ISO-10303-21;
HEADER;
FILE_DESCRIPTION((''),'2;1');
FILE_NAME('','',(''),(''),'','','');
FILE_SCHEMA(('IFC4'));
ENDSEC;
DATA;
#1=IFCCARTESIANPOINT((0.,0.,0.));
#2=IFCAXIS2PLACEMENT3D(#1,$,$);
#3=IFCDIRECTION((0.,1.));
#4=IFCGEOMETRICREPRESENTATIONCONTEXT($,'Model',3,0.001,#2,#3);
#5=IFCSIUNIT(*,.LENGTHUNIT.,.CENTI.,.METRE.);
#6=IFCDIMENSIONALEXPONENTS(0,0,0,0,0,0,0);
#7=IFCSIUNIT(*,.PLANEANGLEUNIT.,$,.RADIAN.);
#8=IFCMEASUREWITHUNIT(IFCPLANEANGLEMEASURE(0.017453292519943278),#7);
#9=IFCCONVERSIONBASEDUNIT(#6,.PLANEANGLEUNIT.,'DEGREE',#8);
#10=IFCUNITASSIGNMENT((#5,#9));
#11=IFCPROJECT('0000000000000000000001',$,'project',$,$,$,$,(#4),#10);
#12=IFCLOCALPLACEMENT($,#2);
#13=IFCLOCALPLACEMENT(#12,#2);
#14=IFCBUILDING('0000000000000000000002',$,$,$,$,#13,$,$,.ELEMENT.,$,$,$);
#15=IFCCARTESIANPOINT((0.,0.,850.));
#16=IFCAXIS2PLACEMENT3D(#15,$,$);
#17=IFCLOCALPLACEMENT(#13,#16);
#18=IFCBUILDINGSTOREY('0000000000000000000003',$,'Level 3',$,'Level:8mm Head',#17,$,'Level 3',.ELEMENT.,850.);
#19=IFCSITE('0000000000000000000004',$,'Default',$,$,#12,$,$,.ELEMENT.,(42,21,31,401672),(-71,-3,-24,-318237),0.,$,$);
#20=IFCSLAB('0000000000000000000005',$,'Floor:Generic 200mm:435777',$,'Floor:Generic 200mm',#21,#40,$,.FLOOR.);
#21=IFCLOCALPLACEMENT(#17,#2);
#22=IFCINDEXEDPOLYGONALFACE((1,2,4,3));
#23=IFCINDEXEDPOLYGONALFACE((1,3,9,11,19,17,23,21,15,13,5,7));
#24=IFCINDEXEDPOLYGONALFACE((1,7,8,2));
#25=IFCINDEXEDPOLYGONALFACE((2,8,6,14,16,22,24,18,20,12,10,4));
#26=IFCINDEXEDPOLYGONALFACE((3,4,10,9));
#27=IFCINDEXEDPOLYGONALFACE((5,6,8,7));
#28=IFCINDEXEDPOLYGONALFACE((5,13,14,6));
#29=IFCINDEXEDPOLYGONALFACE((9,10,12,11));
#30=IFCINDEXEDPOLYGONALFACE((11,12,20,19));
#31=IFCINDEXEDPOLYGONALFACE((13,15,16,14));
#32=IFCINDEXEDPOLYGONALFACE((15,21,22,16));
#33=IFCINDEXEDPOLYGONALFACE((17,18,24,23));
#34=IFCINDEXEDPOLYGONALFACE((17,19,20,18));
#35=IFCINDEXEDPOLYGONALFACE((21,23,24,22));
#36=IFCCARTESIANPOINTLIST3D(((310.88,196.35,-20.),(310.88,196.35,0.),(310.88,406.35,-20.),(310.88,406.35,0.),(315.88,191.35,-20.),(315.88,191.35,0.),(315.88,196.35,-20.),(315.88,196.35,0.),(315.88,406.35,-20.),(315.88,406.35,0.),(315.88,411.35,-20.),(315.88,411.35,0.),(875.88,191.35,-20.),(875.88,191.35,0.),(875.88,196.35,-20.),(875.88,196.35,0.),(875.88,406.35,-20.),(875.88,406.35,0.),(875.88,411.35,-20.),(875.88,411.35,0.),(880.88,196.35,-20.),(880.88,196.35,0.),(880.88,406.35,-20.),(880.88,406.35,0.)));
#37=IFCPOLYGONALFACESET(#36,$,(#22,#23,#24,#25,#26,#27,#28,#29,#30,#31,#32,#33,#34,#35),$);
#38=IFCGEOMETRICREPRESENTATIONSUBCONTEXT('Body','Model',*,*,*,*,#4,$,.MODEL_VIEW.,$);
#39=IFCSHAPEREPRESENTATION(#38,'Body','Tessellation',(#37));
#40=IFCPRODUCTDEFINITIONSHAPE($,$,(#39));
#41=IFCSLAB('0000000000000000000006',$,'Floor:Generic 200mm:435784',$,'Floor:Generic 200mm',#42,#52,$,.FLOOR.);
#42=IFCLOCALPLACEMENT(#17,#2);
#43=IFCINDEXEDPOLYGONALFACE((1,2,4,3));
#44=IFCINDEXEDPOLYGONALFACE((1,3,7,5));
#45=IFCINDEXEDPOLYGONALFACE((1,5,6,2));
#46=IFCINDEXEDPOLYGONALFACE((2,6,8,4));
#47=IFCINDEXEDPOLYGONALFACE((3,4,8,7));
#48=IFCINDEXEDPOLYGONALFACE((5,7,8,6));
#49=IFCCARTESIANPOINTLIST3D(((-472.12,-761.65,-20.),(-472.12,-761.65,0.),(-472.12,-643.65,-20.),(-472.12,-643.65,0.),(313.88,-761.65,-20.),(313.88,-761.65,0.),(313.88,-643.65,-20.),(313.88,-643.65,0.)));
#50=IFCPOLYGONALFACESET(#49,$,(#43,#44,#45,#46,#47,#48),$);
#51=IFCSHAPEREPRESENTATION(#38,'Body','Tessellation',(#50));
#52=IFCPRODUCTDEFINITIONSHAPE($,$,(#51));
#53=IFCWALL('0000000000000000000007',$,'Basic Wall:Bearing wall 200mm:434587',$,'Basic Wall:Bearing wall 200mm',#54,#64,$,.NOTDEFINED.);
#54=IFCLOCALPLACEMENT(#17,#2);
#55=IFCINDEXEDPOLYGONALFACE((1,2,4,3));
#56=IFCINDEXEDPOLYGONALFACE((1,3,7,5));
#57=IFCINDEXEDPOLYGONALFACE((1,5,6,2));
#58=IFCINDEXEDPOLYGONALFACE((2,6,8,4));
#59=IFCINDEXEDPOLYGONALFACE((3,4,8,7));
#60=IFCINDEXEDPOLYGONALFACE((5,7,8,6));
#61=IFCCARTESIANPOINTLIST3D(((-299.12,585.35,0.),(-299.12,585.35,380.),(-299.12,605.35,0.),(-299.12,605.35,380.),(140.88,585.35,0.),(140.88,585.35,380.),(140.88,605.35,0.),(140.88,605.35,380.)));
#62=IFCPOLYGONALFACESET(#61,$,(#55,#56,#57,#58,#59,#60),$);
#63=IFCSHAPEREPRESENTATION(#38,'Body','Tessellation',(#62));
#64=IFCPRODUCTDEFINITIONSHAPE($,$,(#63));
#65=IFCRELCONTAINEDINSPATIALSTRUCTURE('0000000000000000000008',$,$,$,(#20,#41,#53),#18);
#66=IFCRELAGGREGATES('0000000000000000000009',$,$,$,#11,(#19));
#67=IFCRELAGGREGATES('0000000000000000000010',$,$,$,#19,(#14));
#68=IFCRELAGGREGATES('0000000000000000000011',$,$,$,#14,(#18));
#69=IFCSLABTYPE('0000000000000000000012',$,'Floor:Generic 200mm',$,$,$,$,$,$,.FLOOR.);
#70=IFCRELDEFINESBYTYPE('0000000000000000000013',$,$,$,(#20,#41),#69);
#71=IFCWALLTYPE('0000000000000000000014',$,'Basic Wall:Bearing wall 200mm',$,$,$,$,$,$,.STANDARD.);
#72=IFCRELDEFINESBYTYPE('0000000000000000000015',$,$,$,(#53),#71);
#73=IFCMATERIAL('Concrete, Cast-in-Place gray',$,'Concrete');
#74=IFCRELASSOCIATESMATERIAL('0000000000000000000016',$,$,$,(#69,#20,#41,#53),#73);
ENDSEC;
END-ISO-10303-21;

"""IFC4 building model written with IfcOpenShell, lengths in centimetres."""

from ifc_helpers import new_model, entity, si_unit, converted_unit, direction, frame, origin, place, context, subcontext, project, spatial, indexed_curve, outline, extrude, material, type_object, element, save


model = new_model("IFC4")

# Units and contexts
model_context = context("Model", 3, precision=0.001, world=origin(), true_north=direction((0.0, 1.0)))
body_context = subcontext(model_context, "Body", "Model", "MODEL_VIEW")
ifc_project = project(units=[si_unit("LENGTHUNIT", "METRE", prefix="CENTI"), converted_unit("PLANEANGLEUNIT", "DEGREE", entity("IfcPlaneAngleMeasure", 0.017453292519943278), si_unit("PLANEANGLEUNIT", "RADIAN"), dimensions=[0, 0, 0, 0, 0, 0, 0])], contexts=[model_context])

# Site, building, storey
site_placement = place(None, origin())
site = spatial("IfcSite", under=ifc_project, at=site_placement, Name="Default", CompositionType="ELEMENT", RefLatitude=(42, 21, 31, 401672), RefLongitude=(-71, -3, -24, -318237), RefElevation=0.0)
building_placement = place(site_placement, origin())
building = spatial("IfcBuilding", under=site, at=building_placement, CompositionType="ELEMENT")
storey_placement = place(building_placement, frame((0.0, 0.0, 850.0)))
storey = spatial("IfcBuildingStorey", under=building, at=storey_placement, Name="Level 3", ObjectType="Level:8mm Head", LongName="Level 3", CompositionType="ELEMENT", Elevation=850.0)

# Shared definitions
ifc_material = material(Name="Concrete, Cast-in-Place gray", Category="Concrete")
slab_type = type_object("IfcSlabType", Name="Floor:Generic 200mm", PredefinedType="FLOOR", material=ifc_material)

# Slabs
slab_1_placement = place(storey_placement, origin())
element("IfcSlab", 1, at=slab_1_placement, inside=storey, type_object=slab_type, material=ifc_material, Name="Floor:Generic 200mm:435777", ObjectType="Floor:Generic 200mm", PredefinedType="FLOOR", context=body_context, shape_type="SweptSolid", body=[
    extrude(outline(indexed_curve([(-105.0, -285.0), (105.0, -285.0), (105.0, -280.0), (110.0, -280.0), (110.0, 280.0), (105.0, 280.0), (105.0, 285.0), (-105.0, 285.0), (-105.0, 280.0), (-110.0, 280.0), (-110.0, -280.0), (-105.0, -280.0), (-105.0, -285.0)], self_intersect=False)), frame((595.88, 301.35, 0.0), z_axis=(0.0, 0.0, -1.0), x_axis=(0.0, 1.0, 0.0)), (0.0, 0.0, 1.0), 20.0),
])
slab_2_placement = place(storey_placement, origin())
element("IfcSlab", 2, at=slab_2_placement, inside=storey, type_object=slab_type, material=ifc_material, Name="Floor:Generic 200mm:435784", ObjectType="Floor:Generic 200mm", PredefinedType="FLOOR", context=body_context, shape_type="SweptSolid", body=[
    extrude(outline(indexed_curve([(-59.0, -393.0), (59.0, -393.0), (59.0, 393.0), (-59.0, 393.0), (-59.0, -393.0)], self_intersect=False)), frame((-79.12, -702.65, 0.0), z_axis=(0.0, 0.0, -1.0), x_axis=(0.0, 1.0, 0.0)), (0.0, 0.0, 1.0), 20.0),
])

# Wall
wall_type = type_object("IfcWallType", Name="Basic Wall:Bearing wall 200mm", PredefinedType="STANDARD")
wall_placement = place(storey_placement, frame((-299.12, 595.35, 0.0)))
element("IfcWall", 3, at=wall_placement, inside=storey, type_object=wall_type, material=ifc_material, Name="Basic Wall:Bearing wall 200mm:434587", ObjectType="Basic Wall:Bearing wall 200mm", PredefinedType="NOTDEFINED", context=body_context, shape_type="SweptSolid", body=[
    extrude(outline(indexed_curve([(440.0, 10.0), (0.0, 10.0), (0.0, -10.0), (440.0, -10.0), (440.0, 10.0)], self_intersect=False)), origin(), (0.0, 0.0, 1.0), 380.0),
])

save(model, "model.ifc")
